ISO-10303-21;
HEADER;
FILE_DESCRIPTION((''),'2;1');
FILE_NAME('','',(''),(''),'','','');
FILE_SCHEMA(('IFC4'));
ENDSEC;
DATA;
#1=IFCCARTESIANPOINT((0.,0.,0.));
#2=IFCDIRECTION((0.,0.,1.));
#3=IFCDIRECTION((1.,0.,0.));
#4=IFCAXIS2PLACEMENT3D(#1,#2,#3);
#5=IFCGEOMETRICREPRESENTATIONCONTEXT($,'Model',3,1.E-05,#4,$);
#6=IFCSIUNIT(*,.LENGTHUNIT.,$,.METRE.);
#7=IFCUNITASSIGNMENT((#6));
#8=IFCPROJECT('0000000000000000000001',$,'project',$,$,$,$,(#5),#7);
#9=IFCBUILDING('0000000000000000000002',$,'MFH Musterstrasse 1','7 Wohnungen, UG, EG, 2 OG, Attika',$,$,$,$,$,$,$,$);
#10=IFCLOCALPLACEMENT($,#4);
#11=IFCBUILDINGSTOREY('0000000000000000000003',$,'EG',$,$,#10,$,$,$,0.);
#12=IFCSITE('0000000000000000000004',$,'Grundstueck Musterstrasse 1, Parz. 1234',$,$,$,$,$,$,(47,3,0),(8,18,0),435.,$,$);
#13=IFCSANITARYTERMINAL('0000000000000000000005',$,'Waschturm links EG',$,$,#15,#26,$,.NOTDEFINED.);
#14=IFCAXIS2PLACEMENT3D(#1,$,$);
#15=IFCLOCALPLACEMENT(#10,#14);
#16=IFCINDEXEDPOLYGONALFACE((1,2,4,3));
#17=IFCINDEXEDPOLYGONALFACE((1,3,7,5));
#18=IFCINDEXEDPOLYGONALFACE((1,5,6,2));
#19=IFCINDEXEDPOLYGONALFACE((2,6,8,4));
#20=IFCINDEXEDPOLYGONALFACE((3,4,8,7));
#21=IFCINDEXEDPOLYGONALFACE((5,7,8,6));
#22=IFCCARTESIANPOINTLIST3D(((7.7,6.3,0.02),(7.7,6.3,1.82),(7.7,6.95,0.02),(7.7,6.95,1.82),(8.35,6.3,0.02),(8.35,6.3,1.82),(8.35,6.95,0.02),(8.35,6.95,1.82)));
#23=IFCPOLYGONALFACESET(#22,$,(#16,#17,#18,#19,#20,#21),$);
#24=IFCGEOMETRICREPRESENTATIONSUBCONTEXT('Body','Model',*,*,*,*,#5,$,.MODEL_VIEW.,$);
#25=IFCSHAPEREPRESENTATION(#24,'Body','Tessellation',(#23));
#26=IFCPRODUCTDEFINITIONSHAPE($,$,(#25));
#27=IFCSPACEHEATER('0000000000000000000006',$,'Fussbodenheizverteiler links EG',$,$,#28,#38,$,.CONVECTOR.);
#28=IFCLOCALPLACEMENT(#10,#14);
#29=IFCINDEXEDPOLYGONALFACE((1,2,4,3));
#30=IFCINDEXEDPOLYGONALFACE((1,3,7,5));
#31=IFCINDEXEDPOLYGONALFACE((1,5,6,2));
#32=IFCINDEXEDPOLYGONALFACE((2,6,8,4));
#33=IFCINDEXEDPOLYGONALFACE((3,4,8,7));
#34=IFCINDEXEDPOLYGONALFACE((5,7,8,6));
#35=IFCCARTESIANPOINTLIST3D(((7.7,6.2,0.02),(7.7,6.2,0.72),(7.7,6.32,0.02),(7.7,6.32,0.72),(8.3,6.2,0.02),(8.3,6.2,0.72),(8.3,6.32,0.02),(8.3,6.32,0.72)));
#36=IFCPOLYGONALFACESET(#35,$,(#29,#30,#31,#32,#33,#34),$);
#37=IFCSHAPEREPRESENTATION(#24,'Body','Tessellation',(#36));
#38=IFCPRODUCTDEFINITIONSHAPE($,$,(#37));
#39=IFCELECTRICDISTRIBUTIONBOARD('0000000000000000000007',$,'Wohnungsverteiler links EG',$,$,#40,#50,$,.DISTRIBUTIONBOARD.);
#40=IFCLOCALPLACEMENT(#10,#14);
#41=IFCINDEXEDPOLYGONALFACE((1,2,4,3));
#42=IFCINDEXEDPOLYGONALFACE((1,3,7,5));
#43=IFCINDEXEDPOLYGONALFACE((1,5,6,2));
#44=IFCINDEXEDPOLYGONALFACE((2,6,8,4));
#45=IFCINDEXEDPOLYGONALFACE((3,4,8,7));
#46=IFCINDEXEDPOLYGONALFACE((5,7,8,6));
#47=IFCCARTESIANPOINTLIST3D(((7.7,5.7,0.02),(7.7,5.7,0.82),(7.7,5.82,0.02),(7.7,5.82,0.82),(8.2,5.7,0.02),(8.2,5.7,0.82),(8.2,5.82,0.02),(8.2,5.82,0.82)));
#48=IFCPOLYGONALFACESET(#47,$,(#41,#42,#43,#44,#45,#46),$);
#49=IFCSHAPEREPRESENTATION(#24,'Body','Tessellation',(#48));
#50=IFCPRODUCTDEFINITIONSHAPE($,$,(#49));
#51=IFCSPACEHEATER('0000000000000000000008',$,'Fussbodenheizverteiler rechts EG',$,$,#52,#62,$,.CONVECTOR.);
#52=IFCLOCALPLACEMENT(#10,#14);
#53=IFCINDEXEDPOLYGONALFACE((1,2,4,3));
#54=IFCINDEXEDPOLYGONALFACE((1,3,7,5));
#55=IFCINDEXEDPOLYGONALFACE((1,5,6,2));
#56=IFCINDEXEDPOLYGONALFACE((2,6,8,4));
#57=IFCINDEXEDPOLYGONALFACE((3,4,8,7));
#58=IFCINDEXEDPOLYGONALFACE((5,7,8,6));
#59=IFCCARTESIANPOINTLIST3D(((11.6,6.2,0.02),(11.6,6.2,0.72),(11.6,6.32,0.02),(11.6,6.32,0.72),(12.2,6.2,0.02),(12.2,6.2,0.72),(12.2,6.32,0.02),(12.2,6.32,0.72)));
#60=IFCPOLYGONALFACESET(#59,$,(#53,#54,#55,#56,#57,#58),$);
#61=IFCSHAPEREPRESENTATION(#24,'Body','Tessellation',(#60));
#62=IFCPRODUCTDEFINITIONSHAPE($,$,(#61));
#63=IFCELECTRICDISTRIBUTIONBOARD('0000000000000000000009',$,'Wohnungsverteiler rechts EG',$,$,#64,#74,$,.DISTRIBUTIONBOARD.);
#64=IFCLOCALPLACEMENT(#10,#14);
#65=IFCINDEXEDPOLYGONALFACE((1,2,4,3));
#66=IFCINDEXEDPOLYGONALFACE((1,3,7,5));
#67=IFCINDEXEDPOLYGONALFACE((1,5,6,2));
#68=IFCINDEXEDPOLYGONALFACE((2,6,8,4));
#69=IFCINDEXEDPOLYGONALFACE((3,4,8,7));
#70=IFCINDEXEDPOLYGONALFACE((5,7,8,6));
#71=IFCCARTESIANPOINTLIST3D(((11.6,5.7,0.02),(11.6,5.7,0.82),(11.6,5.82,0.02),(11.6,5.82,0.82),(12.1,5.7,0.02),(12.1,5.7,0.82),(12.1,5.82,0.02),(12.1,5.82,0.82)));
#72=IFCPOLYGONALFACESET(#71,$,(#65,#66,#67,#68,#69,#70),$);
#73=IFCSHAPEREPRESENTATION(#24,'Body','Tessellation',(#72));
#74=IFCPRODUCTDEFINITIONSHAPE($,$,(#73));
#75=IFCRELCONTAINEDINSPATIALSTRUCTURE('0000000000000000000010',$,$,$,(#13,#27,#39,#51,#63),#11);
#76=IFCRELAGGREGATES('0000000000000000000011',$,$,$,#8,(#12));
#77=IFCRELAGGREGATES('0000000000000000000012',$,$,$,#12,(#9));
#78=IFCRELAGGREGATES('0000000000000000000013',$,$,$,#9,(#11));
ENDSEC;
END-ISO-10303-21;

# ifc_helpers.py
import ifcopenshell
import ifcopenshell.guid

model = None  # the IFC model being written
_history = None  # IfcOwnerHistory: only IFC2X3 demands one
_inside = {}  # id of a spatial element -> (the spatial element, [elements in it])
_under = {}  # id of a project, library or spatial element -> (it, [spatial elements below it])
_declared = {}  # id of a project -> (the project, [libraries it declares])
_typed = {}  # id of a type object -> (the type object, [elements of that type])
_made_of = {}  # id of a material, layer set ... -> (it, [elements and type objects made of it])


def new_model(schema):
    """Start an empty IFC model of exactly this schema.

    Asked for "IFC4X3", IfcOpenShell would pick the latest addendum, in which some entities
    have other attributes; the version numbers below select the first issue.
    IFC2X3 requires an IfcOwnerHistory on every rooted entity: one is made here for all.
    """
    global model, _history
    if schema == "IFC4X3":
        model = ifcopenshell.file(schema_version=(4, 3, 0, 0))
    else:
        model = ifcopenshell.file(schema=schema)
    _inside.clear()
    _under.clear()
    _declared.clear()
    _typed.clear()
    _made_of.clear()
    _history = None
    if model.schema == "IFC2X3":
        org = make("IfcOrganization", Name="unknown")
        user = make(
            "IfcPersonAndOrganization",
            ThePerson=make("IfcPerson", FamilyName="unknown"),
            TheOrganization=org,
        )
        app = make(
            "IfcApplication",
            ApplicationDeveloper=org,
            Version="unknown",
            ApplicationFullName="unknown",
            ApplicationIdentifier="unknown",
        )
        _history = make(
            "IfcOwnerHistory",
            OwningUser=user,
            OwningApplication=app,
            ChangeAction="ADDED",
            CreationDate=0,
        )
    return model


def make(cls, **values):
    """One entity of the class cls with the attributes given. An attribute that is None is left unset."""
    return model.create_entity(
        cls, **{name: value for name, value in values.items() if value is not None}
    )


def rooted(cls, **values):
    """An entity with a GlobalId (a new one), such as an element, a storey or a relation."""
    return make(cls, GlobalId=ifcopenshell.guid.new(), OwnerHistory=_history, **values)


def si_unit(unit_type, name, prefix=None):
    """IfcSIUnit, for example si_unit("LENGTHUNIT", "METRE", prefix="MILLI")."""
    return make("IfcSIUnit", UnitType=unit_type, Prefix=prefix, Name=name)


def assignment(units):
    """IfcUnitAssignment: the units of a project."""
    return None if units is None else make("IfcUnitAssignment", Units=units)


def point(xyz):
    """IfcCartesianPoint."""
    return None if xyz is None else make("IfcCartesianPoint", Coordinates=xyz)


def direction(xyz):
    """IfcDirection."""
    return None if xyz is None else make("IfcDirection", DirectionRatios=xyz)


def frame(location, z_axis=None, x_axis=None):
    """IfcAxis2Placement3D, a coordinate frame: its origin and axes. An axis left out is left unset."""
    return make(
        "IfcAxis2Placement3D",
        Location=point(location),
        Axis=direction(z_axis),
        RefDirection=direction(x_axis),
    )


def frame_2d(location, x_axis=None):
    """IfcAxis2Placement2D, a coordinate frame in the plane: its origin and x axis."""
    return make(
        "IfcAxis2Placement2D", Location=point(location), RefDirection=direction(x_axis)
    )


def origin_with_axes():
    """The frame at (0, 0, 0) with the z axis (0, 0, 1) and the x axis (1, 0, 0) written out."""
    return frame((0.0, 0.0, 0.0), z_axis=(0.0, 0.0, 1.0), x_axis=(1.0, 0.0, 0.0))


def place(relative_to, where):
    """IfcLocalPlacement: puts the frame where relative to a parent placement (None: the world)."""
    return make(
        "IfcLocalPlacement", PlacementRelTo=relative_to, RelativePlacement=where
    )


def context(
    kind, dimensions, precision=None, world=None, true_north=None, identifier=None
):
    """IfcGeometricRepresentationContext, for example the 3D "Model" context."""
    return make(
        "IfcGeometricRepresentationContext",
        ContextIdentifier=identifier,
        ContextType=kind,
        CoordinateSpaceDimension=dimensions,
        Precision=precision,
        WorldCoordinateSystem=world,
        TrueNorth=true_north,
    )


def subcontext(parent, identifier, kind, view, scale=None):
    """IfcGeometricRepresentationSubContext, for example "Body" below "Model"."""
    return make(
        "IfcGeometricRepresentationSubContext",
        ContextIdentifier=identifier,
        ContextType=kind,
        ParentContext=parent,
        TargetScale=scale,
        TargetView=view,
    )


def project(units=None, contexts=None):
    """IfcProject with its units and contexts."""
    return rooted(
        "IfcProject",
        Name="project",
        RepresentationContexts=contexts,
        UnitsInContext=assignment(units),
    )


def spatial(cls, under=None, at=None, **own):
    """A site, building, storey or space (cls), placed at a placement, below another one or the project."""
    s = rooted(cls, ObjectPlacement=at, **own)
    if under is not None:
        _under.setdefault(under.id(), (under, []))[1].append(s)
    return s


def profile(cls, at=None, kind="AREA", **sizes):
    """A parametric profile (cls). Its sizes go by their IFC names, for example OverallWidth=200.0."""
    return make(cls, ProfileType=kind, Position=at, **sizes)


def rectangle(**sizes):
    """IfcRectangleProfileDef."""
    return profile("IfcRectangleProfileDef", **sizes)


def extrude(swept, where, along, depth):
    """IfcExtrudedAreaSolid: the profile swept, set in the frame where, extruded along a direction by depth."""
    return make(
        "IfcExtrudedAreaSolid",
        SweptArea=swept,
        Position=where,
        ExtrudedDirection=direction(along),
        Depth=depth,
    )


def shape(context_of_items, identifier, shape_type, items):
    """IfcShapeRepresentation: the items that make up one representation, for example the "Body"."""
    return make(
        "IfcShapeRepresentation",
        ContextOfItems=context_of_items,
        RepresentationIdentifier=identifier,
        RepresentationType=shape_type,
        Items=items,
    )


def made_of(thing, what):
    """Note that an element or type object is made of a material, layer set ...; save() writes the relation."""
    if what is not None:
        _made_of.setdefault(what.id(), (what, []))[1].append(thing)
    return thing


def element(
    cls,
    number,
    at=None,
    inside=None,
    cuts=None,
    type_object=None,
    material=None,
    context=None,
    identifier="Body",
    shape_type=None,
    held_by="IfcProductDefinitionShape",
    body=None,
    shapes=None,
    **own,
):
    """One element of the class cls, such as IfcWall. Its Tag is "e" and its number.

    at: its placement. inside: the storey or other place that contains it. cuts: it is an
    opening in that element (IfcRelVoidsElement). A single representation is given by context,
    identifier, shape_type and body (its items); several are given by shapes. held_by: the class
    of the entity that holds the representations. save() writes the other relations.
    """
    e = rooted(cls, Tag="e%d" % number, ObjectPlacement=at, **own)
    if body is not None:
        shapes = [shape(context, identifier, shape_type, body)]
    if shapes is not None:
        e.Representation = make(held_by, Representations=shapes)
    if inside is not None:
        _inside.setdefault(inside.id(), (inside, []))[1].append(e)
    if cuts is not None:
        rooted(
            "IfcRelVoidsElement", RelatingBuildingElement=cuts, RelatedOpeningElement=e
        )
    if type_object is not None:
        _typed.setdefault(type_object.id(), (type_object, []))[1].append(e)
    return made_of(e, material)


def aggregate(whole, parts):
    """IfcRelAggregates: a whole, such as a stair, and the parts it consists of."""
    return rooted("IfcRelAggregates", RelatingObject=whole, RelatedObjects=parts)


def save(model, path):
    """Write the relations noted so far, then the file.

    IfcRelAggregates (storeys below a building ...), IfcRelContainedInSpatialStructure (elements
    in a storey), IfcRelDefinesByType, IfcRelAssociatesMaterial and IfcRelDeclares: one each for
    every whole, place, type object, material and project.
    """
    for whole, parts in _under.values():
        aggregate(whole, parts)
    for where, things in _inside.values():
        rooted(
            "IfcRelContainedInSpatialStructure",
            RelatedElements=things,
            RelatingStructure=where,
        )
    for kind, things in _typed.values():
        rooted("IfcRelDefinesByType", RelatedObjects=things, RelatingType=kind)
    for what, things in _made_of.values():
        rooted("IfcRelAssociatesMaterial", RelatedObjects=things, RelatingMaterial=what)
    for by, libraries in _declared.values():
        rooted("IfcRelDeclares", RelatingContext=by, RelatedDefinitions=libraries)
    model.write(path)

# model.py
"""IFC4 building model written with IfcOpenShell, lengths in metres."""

from ifc_helpers import new_model, si_unit, frame, frame_2d, origin_with_axes, place, context, subcontext, project, spatial, rectangle, extrude, element, save


model = new_model("IFC4")

# Units and contexts
model_context = context("Model", 3, precision=1e-05, world=origin_with_axes())
body_context = subcontext(model_context, "Body", "Model", "MODEL_VIEW")
ifc_project = project(units=[si_unit("LENGTHUNIT", "METRE")], contexts=[model_context])

# Site, building, storey
site = spatial("IfcSite", under=ifc_project, Name="Grundstueck Musterstrasse 1, Parz. 1234", RefLatitude=(47, 3, 0), RefLongitude=(8, 18, 0), RefElevation=435.0)
building = spatial("IfcBuilding", under=site, Name="MFH Musterstrasse 1", Description="7 Wohnungen, UG, EG, 2 OG, Attika")
storey_placement = place(None, origin_with_axes())
storey = spatial("IfcBuildingStorey", under=building, at=storey_placement, Name="EG", Elevation=0.0)

# Sanitary terminal
sanitary_terminal_placement = place(storey_placement, frame((7.7, 6.3, 0.02), z_axis=(0.0, 0.0, 1.0), x_axis=(1.0, 0.0, 0.0)))
element("IfcSanitaryTerminal", 1, at=sanitary_terminal_placement, inside=storey, Name="Waschturm links EG", PredefinedType="NOTDEFINED", context=body_context, shape_type="SweptSolid", body=[
    extrude(rectangle(XDim=0.65, YDim=0.65, at=frame_2d((0.325, 0.325))), origin_with_axes(), (0.0, 0.0, 1.0), 1.8),
])

# Space heater
space_heater_1_placement = place(storey_placement, frame((7.7, 6.2, 0.02), z_axis=(0.0, 0.0, 1.0), x_axis=(1.0, 0.0, 0.0)))
element("IfcSpaceHeater", 2, at=space_heater_1_placement, inside=storey, Name="Fussbodenheizverteiler links EG", PredefinedType="CONVECTOR", context=body_context, shape_type="SweptSolid", body=[
    extrude(rectangle(XDim=0.6, YDim=0.12, at=frame_2d((0.3, 0.06))), origin_with_axes(), (0.0, 0.0, 1.0), 0.7),
])

# Electric distribution board
electric_distribution_board_1_placement = place(storey_placement, frame((7.7, 5.7, 0.02), z_axis=(0.0, 0.0, 1.0), x_axis=(1.0, 0.0, 0.0)))
element("IfcElectricDistributionBoard", 3, at=electric_distribution_board_1_placement, inside=storey, Name="Wohnungsverteiler links EG", PredefinedType="DISTRIBUTIONBOARD", context=body_context, shape_type="SweptSolid", body=[
    extrude(rectangle(XDim=0.5, YDim=0.12, at=frame_2d((0.25, 0.06))), origin_with_axes(), (0.0, 0.0, 1.0), 0.8),
])

# Space heater
space_heater_2_placement = place(storey_placement, frame((11.6, 6.2, 0.02), z_axis=(0.0, 0.0, 1.0), x_axis=(1.0, 0.0, 0.0)))
element("IfcSpaceHeater", 4, at=space_heater_2_placement, inside=storey, Name="Fussbodenheizverteiler rechts EG", PredefinedType="CONVECTOR", context=body_context, shape_type="SweptSolid", body=[
    extrude(rectangle(XDim=0.6, YDim=0.12, at=frame_2d((0.3, 0.06))), origin_with_axes(), (0.0, 0.0, 1.0), 0.7),
])

# Electric distribution board
electric_distribution_board_2_placement = place(storey_placement, frame((11.6, 5.7, 0.02), z_axis=(0.0, 0.0, 1.0), x_axis=(1.0, 0.0, 0.0)))
element("IfcElectricDistributionBoard", 5, at=electric_distribution_board_2_placement, inside=storey, Name="Wohnungsverteiler rechts EG", PredefinedType="DISTRIBUTIONBOARD", context=body_context, shape_type="SweptSolid", body=[
    extrude(rectangle(XDim=0.5, YDim=0.12, at=frame_2d((0.25, 0.06))), origin_with_axes(), (0.0, 0.0, 1.0), 0.8),
])

save(model, "model.ifc")
